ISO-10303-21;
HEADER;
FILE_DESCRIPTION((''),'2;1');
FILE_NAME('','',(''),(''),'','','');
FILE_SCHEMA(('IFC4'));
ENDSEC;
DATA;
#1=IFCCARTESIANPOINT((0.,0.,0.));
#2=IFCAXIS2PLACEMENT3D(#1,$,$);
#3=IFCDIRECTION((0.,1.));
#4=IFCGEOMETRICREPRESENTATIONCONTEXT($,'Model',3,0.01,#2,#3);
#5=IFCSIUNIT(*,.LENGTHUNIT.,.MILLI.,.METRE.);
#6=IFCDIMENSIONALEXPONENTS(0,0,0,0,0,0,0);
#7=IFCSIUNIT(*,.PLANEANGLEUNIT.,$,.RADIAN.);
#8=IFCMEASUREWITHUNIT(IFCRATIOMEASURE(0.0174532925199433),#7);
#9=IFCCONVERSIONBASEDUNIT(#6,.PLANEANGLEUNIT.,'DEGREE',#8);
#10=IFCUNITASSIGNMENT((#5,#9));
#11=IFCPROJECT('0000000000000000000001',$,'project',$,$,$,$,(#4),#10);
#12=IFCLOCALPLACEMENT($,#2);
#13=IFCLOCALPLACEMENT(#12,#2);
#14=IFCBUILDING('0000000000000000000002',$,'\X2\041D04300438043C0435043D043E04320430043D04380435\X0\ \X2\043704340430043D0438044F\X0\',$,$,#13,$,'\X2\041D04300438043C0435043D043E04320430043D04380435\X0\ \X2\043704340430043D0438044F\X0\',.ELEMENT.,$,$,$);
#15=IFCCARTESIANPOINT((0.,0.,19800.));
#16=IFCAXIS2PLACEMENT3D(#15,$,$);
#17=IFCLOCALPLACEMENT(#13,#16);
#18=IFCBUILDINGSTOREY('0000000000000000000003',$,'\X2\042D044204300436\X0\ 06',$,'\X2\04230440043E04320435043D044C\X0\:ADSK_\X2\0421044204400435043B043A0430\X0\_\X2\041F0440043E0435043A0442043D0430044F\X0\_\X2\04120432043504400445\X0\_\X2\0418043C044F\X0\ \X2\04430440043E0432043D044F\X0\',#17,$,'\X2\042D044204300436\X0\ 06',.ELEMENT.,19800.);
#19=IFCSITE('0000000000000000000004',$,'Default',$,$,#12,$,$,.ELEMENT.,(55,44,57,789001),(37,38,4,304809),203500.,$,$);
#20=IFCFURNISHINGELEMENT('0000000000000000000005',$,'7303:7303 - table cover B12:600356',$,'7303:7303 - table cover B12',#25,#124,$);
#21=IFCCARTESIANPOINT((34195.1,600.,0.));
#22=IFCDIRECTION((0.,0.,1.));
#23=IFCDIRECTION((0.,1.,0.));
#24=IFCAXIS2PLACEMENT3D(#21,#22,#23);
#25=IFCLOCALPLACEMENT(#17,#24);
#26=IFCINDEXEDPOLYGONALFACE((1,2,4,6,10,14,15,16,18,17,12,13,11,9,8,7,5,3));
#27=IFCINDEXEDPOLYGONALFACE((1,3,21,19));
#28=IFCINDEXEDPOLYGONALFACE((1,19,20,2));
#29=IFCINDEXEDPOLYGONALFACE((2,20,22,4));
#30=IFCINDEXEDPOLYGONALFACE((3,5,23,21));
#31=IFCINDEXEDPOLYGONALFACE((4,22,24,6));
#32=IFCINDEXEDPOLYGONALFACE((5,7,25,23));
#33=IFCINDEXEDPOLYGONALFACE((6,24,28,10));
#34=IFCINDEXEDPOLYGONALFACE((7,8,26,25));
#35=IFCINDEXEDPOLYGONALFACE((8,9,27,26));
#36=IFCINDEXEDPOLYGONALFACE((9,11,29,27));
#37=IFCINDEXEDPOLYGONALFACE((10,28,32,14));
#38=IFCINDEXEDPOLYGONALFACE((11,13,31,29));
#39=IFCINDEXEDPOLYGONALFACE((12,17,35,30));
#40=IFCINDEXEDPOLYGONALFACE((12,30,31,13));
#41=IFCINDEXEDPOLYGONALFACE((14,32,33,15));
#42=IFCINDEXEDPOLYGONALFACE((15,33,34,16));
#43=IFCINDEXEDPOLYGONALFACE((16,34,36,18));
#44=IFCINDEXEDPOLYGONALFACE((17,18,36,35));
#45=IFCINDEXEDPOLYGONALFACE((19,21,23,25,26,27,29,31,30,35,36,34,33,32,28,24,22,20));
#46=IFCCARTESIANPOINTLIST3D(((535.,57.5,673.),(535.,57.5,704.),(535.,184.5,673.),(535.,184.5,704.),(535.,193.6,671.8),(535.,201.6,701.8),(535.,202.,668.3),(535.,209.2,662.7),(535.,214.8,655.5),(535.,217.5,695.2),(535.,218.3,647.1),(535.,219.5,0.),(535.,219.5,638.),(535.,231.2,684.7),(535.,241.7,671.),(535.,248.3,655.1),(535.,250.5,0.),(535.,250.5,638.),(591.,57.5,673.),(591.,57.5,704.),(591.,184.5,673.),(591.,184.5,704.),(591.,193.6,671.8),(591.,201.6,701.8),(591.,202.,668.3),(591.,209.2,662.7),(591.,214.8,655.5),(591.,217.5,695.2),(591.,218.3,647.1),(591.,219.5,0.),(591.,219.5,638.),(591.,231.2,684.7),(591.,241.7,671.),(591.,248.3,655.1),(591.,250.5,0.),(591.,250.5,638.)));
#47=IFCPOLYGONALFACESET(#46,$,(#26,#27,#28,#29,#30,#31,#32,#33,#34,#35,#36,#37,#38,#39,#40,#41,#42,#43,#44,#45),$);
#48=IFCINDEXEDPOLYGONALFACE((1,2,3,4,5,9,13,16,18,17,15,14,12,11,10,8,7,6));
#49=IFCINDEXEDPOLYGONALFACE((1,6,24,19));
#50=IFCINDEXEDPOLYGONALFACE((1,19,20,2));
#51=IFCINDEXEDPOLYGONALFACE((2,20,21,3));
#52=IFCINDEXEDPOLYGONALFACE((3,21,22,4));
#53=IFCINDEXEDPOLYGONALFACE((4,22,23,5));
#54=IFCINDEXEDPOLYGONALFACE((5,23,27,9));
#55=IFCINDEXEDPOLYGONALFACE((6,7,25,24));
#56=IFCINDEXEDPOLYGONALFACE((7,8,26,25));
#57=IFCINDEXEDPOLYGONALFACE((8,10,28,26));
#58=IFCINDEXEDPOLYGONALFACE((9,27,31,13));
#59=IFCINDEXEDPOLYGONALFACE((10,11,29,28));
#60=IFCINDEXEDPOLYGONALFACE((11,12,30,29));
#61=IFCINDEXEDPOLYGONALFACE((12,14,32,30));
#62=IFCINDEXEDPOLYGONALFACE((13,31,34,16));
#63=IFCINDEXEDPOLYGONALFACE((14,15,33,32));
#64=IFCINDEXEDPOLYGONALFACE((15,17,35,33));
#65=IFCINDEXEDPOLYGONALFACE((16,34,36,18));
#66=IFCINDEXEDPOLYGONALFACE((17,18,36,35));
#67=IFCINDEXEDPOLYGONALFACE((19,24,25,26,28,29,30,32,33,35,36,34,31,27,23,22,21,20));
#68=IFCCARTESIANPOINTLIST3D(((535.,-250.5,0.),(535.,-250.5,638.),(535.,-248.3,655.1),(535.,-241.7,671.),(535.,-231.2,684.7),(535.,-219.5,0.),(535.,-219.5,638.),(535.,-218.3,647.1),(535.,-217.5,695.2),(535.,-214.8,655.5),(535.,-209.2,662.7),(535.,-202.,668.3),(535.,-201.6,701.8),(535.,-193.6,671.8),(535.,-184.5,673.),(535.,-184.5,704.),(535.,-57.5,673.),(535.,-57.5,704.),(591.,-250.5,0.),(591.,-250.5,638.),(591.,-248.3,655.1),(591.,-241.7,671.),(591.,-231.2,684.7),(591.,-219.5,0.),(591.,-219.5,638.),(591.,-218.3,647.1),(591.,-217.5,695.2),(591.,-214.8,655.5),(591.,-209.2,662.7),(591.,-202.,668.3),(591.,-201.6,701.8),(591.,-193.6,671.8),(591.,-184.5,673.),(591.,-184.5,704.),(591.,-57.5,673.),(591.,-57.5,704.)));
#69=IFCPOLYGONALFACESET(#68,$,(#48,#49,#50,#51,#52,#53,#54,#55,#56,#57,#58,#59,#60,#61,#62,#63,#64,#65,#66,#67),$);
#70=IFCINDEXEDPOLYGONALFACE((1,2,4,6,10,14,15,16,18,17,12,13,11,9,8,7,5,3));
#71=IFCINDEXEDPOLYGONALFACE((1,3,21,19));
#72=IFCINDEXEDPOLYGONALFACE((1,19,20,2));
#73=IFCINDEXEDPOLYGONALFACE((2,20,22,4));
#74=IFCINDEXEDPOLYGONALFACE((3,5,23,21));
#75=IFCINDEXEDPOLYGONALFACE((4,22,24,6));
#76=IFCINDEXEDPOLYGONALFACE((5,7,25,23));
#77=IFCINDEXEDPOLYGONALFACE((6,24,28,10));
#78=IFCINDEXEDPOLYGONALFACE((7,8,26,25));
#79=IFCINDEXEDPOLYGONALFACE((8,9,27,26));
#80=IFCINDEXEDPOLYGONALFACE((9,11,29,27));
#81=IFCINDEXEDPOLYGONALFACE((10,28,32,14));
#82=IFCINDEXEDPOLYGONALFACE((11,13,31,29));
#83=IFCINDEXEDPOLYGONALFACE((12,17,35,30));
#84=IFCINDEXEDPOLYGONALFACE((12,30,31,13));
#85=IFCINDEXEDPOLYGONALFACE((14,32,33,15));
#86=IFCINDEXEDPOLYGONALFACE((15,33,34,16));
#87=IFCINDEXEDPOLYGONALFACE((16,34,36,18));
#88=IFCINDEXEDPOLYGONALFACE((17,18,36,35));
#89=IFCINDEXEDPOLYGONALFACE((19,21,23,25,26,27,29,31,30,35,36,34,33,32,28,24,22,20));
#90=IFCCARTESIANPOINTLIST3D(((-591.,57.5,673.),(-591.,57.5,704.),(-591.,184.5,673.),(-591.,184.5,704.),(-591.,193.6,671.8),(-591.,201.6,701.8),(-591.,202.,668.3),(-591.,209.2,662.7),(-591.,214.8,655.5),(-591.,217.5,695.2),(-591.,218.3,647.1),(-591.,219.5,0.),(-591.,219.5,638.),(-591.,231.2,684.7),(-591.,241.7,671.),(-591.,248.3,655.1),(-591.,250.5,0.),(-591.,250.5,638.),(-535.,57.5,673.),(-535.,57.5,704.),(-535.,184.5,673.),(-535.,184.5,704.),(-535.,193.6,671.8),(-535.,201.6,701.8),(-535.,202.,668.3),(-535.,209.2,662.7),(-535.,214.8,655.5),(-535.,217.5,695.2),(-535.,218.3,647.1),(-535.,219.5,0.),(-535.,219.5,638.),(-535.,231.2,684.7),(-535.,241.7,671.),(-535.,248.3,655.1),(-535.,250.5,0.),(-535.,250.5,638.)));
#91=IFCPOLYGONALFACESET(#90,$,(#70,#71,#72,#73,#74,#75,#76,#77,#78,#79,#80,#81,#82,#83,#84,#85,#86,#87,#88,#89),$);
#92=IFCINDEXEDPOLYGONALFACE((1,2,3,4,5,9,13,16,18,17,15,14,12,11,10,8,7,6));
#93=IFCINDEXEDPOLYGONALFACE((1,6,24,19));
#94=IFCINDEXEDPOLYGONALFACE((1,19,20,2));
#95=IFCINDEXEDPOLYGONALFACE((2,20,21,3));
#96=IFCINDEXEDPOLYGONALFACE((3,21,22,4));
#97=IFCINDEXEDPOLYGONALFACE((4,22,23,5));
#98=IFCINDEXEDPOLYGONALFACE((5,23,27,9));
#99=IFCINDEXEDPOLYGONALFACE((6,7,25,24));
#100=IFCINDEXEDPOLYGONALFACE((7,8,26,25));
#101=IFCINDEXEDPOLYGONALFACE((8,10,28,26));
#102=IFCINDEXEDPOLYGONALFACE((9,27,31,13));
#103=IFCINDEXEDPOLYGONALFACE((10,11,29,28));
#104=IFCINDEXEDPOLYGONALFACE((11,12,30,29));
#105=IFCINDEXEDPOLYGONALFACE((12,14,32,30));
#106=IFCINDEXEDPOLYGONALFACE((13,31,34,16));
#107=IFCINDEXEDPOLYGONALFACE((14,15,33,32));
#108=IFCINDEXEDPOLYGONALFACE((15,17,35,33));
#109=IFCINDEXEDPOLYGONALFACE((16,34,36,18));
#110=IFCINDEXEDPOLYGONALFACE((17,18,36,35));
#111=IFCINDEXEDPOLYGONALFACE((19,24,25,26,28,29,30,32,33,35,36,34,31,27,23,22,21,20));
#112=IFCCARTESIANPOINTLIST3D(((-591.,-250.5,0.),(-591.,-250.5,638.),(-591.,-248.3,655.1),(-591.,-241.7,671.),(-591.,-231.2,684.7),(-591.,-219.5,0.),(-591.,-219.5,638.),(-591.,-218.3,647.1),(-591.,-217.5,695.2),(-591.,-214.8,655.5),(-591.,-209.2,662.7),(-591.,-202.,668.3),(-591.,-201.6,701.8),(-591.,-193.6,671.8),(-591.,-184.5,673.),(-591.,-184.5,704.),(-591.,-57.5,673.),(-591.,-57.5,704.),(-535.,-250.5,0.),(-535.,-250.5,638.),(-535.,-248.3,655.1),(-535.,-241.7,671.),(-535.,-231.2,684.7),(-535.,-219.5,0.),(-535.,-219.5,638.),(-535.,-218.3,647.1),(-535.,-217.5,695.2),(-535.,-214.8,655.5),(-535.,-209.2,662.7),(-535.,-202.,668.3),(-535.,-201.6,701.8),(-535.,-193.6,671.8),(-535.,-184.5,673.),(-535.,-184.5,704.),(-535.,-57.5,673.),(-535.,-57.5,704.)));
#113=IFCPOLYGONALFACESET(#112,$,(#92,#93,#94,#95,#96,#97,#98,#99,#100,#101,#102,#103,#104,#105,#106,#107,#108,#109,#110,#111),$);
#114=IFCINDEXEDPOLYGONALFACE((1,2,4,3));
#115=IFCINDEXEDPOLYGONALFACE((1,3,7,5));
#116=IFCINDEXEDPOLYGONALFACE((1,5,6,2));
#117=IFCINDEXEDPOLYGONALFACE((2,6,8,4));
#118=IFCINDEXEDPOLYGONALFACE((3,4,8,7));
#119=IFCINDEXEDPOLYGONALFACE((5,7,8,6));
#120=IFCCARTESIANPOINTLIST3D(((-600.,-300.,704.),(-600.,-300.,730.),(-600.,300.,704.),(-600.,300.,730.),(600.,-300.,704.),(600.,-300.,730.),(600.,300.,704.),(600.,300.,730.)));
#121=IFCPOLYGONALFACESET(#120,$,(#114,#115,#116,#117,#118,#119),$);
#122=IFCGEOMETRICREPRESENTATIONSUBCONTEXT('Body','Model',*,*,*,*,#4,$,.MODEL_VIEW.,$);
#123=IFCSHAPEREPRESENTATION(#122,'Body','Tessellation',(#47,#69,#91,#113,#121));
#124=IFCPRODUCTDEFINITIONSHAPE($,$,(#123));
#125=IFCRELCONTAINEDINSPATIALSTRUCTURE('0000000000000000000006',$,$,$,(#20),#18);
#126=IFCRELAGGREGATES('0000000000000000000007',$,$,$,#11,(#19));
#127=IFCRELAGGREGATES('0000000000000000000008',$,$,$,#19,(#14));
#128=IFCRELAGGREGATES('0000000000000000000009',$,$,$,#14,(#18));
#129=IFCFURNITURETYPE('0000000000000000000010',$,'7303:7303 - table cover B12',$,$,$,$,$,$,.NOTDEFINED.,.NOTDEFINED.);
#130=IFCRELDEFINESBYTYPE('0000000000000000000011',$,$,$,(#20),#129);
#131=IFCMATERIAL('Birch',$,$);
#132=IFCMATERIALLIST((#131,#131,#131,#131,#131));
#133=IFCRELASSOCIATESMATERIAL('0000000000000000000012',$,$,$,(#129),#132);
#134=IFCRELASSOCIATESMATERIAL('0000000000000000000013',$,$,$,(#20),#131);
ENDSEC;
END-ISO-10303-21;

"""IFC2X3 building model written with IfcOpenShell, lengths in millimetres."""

from ifc_helpers import new_model, entity, si_unit, converted_unit, direction, frame, frame_2d, origin, origin_2d_with_axis, place, context, subcontext, project, spatial, polyline, circle_curve, parameter, trimmed, segment, composite_curve, rectangle, outline, extrude, source, transform, mapped, material, material_list, type_object, type_shapes, element, save


model = new_model("IFC2X3")

# Units and contexts
model_context = context("Model", 3, precision=0.01, world=origin(), true_north=direction((0.0, 1.0)))
body_context = subcontext(model_context, "Body", "Model", "MODEL_VIEW")
ifc_project = project(units=[si_unit("LENGTHUNIT", "METRE", prefix="MILLI"), converted_unit("PLANEANGLEUNIT", "DEGREE", entity("IfcRatioMeasure", 0.0174532925199433), si_unit("PLANEANGLEUNIT", "RADIAN"), dimensions=[0, 0, 0, 0, 0, 0, 0])], contexts=[model_context])

# Site, building, storey
site_placement = place(None, origin())
site = spatial("IfcSite", under=ifc_project, at=site_placement, Name="Default", CompositionType="ELEMENT", RefLatitude=(55, 44, 57, 789001), RefLongitude=(37, 38, 4, 304809), RefElevation=203500.0)
building_placement = place(site_placement, origin())
building = spatial("IfcBuilding", under=site, at=building_placement, Name="Наименование здания", LongName="Наименование здания", CompositionType="ELEMENT")
storey_placement = place(building_placement, frame((0.0, 0.0, 19800.0)))
storey = spatial("IfcBuildingStorey", under=building, at=storey_placement, Name="Этаж 06", ObjectType="Уровень:ADSK_Стрелка_Проектная_Вверх_Имя уровня", LongName="Этаж 06", CompositionType="ELEMENT", Elevation=19800.0)

# Furnishing element
ifc_material_1 = material(Name="Birch")
ifc_material_list_1 = material_list([ifc_material_1, ifc_material_1, ifc_material_1, ifc_material_1, ifc_material_1])
furniture_type = type_object("IfcFurnitureType", Name="7303:7303 - table cover B12", material=ifc_material_list_1)
shared_shape_1 = source(origin(), body_context, "Body", "SweptSolid", [
    extrude(outline(composite_curve([segment(polyline([(-200.2, -120.5), (-169.2, -120.5)]), True, "CONTINUOUS"), segment(polyline([(-169.2, -120.5), (-169.2, 6.5)]), True, "CONTINUOUS"), segment(trimmed(circle_curve(frame_2d((-134.2, 6.5), x_axis=(0.0, -1.0)), 35.0), [parameter(180.0)], [parameter(270.0)], True, "PARAMETER"), False, "CONTINUOUS"), segment(polyline([(-134.2, 41.5), (503.8, 41.5)]), True, "CONTINUOUS"), segment(polyline([(503.8, 41.5), (503.8, 72.5)]), True, "CONTINUOUS"), segment(polyline([(503.8, 72.5), (-134.2, 72.5)]), True, "CONTINUOUS"), segment(trimmed(circle_curve(frame_2d((-134.2, 6.5), x_axis=(0.0, -1.0)), 66.0), [parameter(180.0)], [parameter(270.0)], True, "PARAMETER"), True, "CONTINUOUS"), segment(polyline([(-200.2, 6.5), (-200.2, -120.5)]), True, "CONTINUOUS")], self_intersect=False)), frame((535.0, 178.0, 503.8), z_axis=(1.0, 0.0, 0.0), x_axis=(0.0, 0.0, -1.0)), (0.0, 0.0, 1.0), 56.0),
    extrude(outline(composite_curve([segment(polyline([(-120.5, -200.2), (6.5, -200.2)]), True, "CONTINUOUS"), segment(trimmed(circle_curve(frame_2d((6.5, -134.2), x_axis=(-1.0, 0.0)), 66.0), [parameter(90.0)], [parameter(180.0)], True, "PARAMETER"), True, "CONTINUOUS"), segment(polyline([(72.5, -134.2), (72.5, 503.8)]), True, "CONTINUOUS"), segment(polyline([(72.5, 503.8), (41.5, 503.8)]), True, "CONTINUOUS"), segment(polyline([(41.5, 503.8), (41.5, -134.2)]), True, "CONTINUOUS"), segment(trimmed(circle_curve(frame_2d((6.5, -134.2), x_axis=(-1.0, 0.0)), 35.0), [parameter(90.0)], [parameter(180.0)], True, "PARAMETER"), False, "CONTINUOUS"), segment(polyline([(6.5, -169.2), (-120.5, -169.2)]), True, "CONTINUOUS"), segment(polyline([(-120.5, -169.2), (-120.5, -200.2)]), True, "CONTINUOUS")], self_intersect=False)), frame((535.0, -178.0, 503.8), z_axis=(1.0, 0.0, 0.0), x_axis=(0.0, -1.0, 0.0)), (0.0, 0.0, 1.0), 56.0),
    extrude(outline(composite_curve([segment(polyline([(-200.2, -120.5), (-169.2, -120.5)]), True, "CONTINUOUS"), segment(polyline([(-169.2, -120.5), (-169.2, 6.5)]), True, "CONTINUOUS"), segment(trimmed(circle_curve(frame_2d((-134.2, 6.5), x_axis=(0.0, -1.0)), 35.0), [parameter(180.0)], [parameter(270.0)], True, "PARAMETER"), False, "CONTINUOUS"), segment(polyline([(-134.2, 41.5), (503.8, 41.5)]), True, "CONTINUOUS"), segment(polyline([(503.8, 41.5), (503.8, 72.5)]), True, "CONTINUOUS"), segment(polyline([(503.8, 72.5), (-134.2, 72.5)]), True, "CONTINUOUS"), segment(trimmed(circle_curve(frame_2d((-134.2, 6.5), x_axis=(0.0, -1.0)), 66.0), [parameter(180.0)], [parameter(270.0)], True, "PARAMETER"), True, "CONTINUOUS"), segment(polyline([(-200.2, 6.5), (-200.2, -120.5)]), True, "CONTINUOUS")], self_intersect=False)), frame((-591.0, 178.0, 503.8), z_axis=(1.0, 0.0, 0.0), x_axis=(0.0, 0.0, -1.0)), (0.0, 0.0, 1.0), 56.0),
    extrude(outline(composite_curve([segment(polyline([(-120.5, -200.2), (6.5, -200.2)]), True, "CONTINUOUS"), segment(trimmed(circle_curve(frame_2d((6.5, -134.2), x_axis=(-1.0, 0.0)), 66.0), [parameter(90.0)], [parameter(180.0)], True, "PARAMETER"), True, "CONTINUOUS"), segment(polyline([(72.5, -134.2), (72.5, 503.8)]), True, "CONTINUOUS"), segment(polyline([(72.5, 503.8), (41.5, 503.8)]), True, "CONTINUOUS"), segment(polyline([(41.5, 503.8), (41.5, -134.2)]), True, "CONTINUOUS"), segment(trimmed(circle_curve(frame_2d((6.5, -134.2), x_axis=(-1.0, 0.0)), 35.0), [parameter(90.0)], [parameter(180.0)], True, "PARAMETER"), False, "CONTINUOUS"), segment(polyline([(6.5, -169.2), (-120.5, -169.2)]), True, "CONTINUOUS"), segment(polyline([(-120.5, -169.2), (-120.5, -200.2)]), True, "CONTINUOUS")], self_intersect=False)), frame((-591.0, -178.0, 503.8), z_axis=(1.0, 0.0, 0.0), x_axis=(0.0, -1.0, 0.0)), (0.0, 0.0, 1.0), 56.0),
    extrude(rectangle(XDim=1200.0, YDim=600.0, at=origin_2d_with_axis()), frame((0.0, 0.0, 704.0), z_axis=(0.0, 0.0, 1.0), x_axis=(-1.0, 0.0, 0.0)), (0.0, 0.0, 1.0), 26.0),
])
type_shapes(furniture_type, [shared_shape_1])
furnishing_placement = place(storey_placement, frame((34195.1, 600.0, 0.0), z_axis=(0.0, 0.0, 1.0), x_axis=(0.0, 1.0, 0.0)))
element("IfcFurnishingElement", 1, at=furnishing_placement, inside=storey, type_object=furniture_type, material=ifc_material_1, Name="7303:7303 - table cover B12:600356", ObjectType="7303:7303 - table cover B12", context=body_context, shape_type="MappedRepresentation", body=[
    mapped(shared_shape_1, transform((0.0, 0.0, 0.0), scale=1.0)),
])

save(model, "model.ifc")
